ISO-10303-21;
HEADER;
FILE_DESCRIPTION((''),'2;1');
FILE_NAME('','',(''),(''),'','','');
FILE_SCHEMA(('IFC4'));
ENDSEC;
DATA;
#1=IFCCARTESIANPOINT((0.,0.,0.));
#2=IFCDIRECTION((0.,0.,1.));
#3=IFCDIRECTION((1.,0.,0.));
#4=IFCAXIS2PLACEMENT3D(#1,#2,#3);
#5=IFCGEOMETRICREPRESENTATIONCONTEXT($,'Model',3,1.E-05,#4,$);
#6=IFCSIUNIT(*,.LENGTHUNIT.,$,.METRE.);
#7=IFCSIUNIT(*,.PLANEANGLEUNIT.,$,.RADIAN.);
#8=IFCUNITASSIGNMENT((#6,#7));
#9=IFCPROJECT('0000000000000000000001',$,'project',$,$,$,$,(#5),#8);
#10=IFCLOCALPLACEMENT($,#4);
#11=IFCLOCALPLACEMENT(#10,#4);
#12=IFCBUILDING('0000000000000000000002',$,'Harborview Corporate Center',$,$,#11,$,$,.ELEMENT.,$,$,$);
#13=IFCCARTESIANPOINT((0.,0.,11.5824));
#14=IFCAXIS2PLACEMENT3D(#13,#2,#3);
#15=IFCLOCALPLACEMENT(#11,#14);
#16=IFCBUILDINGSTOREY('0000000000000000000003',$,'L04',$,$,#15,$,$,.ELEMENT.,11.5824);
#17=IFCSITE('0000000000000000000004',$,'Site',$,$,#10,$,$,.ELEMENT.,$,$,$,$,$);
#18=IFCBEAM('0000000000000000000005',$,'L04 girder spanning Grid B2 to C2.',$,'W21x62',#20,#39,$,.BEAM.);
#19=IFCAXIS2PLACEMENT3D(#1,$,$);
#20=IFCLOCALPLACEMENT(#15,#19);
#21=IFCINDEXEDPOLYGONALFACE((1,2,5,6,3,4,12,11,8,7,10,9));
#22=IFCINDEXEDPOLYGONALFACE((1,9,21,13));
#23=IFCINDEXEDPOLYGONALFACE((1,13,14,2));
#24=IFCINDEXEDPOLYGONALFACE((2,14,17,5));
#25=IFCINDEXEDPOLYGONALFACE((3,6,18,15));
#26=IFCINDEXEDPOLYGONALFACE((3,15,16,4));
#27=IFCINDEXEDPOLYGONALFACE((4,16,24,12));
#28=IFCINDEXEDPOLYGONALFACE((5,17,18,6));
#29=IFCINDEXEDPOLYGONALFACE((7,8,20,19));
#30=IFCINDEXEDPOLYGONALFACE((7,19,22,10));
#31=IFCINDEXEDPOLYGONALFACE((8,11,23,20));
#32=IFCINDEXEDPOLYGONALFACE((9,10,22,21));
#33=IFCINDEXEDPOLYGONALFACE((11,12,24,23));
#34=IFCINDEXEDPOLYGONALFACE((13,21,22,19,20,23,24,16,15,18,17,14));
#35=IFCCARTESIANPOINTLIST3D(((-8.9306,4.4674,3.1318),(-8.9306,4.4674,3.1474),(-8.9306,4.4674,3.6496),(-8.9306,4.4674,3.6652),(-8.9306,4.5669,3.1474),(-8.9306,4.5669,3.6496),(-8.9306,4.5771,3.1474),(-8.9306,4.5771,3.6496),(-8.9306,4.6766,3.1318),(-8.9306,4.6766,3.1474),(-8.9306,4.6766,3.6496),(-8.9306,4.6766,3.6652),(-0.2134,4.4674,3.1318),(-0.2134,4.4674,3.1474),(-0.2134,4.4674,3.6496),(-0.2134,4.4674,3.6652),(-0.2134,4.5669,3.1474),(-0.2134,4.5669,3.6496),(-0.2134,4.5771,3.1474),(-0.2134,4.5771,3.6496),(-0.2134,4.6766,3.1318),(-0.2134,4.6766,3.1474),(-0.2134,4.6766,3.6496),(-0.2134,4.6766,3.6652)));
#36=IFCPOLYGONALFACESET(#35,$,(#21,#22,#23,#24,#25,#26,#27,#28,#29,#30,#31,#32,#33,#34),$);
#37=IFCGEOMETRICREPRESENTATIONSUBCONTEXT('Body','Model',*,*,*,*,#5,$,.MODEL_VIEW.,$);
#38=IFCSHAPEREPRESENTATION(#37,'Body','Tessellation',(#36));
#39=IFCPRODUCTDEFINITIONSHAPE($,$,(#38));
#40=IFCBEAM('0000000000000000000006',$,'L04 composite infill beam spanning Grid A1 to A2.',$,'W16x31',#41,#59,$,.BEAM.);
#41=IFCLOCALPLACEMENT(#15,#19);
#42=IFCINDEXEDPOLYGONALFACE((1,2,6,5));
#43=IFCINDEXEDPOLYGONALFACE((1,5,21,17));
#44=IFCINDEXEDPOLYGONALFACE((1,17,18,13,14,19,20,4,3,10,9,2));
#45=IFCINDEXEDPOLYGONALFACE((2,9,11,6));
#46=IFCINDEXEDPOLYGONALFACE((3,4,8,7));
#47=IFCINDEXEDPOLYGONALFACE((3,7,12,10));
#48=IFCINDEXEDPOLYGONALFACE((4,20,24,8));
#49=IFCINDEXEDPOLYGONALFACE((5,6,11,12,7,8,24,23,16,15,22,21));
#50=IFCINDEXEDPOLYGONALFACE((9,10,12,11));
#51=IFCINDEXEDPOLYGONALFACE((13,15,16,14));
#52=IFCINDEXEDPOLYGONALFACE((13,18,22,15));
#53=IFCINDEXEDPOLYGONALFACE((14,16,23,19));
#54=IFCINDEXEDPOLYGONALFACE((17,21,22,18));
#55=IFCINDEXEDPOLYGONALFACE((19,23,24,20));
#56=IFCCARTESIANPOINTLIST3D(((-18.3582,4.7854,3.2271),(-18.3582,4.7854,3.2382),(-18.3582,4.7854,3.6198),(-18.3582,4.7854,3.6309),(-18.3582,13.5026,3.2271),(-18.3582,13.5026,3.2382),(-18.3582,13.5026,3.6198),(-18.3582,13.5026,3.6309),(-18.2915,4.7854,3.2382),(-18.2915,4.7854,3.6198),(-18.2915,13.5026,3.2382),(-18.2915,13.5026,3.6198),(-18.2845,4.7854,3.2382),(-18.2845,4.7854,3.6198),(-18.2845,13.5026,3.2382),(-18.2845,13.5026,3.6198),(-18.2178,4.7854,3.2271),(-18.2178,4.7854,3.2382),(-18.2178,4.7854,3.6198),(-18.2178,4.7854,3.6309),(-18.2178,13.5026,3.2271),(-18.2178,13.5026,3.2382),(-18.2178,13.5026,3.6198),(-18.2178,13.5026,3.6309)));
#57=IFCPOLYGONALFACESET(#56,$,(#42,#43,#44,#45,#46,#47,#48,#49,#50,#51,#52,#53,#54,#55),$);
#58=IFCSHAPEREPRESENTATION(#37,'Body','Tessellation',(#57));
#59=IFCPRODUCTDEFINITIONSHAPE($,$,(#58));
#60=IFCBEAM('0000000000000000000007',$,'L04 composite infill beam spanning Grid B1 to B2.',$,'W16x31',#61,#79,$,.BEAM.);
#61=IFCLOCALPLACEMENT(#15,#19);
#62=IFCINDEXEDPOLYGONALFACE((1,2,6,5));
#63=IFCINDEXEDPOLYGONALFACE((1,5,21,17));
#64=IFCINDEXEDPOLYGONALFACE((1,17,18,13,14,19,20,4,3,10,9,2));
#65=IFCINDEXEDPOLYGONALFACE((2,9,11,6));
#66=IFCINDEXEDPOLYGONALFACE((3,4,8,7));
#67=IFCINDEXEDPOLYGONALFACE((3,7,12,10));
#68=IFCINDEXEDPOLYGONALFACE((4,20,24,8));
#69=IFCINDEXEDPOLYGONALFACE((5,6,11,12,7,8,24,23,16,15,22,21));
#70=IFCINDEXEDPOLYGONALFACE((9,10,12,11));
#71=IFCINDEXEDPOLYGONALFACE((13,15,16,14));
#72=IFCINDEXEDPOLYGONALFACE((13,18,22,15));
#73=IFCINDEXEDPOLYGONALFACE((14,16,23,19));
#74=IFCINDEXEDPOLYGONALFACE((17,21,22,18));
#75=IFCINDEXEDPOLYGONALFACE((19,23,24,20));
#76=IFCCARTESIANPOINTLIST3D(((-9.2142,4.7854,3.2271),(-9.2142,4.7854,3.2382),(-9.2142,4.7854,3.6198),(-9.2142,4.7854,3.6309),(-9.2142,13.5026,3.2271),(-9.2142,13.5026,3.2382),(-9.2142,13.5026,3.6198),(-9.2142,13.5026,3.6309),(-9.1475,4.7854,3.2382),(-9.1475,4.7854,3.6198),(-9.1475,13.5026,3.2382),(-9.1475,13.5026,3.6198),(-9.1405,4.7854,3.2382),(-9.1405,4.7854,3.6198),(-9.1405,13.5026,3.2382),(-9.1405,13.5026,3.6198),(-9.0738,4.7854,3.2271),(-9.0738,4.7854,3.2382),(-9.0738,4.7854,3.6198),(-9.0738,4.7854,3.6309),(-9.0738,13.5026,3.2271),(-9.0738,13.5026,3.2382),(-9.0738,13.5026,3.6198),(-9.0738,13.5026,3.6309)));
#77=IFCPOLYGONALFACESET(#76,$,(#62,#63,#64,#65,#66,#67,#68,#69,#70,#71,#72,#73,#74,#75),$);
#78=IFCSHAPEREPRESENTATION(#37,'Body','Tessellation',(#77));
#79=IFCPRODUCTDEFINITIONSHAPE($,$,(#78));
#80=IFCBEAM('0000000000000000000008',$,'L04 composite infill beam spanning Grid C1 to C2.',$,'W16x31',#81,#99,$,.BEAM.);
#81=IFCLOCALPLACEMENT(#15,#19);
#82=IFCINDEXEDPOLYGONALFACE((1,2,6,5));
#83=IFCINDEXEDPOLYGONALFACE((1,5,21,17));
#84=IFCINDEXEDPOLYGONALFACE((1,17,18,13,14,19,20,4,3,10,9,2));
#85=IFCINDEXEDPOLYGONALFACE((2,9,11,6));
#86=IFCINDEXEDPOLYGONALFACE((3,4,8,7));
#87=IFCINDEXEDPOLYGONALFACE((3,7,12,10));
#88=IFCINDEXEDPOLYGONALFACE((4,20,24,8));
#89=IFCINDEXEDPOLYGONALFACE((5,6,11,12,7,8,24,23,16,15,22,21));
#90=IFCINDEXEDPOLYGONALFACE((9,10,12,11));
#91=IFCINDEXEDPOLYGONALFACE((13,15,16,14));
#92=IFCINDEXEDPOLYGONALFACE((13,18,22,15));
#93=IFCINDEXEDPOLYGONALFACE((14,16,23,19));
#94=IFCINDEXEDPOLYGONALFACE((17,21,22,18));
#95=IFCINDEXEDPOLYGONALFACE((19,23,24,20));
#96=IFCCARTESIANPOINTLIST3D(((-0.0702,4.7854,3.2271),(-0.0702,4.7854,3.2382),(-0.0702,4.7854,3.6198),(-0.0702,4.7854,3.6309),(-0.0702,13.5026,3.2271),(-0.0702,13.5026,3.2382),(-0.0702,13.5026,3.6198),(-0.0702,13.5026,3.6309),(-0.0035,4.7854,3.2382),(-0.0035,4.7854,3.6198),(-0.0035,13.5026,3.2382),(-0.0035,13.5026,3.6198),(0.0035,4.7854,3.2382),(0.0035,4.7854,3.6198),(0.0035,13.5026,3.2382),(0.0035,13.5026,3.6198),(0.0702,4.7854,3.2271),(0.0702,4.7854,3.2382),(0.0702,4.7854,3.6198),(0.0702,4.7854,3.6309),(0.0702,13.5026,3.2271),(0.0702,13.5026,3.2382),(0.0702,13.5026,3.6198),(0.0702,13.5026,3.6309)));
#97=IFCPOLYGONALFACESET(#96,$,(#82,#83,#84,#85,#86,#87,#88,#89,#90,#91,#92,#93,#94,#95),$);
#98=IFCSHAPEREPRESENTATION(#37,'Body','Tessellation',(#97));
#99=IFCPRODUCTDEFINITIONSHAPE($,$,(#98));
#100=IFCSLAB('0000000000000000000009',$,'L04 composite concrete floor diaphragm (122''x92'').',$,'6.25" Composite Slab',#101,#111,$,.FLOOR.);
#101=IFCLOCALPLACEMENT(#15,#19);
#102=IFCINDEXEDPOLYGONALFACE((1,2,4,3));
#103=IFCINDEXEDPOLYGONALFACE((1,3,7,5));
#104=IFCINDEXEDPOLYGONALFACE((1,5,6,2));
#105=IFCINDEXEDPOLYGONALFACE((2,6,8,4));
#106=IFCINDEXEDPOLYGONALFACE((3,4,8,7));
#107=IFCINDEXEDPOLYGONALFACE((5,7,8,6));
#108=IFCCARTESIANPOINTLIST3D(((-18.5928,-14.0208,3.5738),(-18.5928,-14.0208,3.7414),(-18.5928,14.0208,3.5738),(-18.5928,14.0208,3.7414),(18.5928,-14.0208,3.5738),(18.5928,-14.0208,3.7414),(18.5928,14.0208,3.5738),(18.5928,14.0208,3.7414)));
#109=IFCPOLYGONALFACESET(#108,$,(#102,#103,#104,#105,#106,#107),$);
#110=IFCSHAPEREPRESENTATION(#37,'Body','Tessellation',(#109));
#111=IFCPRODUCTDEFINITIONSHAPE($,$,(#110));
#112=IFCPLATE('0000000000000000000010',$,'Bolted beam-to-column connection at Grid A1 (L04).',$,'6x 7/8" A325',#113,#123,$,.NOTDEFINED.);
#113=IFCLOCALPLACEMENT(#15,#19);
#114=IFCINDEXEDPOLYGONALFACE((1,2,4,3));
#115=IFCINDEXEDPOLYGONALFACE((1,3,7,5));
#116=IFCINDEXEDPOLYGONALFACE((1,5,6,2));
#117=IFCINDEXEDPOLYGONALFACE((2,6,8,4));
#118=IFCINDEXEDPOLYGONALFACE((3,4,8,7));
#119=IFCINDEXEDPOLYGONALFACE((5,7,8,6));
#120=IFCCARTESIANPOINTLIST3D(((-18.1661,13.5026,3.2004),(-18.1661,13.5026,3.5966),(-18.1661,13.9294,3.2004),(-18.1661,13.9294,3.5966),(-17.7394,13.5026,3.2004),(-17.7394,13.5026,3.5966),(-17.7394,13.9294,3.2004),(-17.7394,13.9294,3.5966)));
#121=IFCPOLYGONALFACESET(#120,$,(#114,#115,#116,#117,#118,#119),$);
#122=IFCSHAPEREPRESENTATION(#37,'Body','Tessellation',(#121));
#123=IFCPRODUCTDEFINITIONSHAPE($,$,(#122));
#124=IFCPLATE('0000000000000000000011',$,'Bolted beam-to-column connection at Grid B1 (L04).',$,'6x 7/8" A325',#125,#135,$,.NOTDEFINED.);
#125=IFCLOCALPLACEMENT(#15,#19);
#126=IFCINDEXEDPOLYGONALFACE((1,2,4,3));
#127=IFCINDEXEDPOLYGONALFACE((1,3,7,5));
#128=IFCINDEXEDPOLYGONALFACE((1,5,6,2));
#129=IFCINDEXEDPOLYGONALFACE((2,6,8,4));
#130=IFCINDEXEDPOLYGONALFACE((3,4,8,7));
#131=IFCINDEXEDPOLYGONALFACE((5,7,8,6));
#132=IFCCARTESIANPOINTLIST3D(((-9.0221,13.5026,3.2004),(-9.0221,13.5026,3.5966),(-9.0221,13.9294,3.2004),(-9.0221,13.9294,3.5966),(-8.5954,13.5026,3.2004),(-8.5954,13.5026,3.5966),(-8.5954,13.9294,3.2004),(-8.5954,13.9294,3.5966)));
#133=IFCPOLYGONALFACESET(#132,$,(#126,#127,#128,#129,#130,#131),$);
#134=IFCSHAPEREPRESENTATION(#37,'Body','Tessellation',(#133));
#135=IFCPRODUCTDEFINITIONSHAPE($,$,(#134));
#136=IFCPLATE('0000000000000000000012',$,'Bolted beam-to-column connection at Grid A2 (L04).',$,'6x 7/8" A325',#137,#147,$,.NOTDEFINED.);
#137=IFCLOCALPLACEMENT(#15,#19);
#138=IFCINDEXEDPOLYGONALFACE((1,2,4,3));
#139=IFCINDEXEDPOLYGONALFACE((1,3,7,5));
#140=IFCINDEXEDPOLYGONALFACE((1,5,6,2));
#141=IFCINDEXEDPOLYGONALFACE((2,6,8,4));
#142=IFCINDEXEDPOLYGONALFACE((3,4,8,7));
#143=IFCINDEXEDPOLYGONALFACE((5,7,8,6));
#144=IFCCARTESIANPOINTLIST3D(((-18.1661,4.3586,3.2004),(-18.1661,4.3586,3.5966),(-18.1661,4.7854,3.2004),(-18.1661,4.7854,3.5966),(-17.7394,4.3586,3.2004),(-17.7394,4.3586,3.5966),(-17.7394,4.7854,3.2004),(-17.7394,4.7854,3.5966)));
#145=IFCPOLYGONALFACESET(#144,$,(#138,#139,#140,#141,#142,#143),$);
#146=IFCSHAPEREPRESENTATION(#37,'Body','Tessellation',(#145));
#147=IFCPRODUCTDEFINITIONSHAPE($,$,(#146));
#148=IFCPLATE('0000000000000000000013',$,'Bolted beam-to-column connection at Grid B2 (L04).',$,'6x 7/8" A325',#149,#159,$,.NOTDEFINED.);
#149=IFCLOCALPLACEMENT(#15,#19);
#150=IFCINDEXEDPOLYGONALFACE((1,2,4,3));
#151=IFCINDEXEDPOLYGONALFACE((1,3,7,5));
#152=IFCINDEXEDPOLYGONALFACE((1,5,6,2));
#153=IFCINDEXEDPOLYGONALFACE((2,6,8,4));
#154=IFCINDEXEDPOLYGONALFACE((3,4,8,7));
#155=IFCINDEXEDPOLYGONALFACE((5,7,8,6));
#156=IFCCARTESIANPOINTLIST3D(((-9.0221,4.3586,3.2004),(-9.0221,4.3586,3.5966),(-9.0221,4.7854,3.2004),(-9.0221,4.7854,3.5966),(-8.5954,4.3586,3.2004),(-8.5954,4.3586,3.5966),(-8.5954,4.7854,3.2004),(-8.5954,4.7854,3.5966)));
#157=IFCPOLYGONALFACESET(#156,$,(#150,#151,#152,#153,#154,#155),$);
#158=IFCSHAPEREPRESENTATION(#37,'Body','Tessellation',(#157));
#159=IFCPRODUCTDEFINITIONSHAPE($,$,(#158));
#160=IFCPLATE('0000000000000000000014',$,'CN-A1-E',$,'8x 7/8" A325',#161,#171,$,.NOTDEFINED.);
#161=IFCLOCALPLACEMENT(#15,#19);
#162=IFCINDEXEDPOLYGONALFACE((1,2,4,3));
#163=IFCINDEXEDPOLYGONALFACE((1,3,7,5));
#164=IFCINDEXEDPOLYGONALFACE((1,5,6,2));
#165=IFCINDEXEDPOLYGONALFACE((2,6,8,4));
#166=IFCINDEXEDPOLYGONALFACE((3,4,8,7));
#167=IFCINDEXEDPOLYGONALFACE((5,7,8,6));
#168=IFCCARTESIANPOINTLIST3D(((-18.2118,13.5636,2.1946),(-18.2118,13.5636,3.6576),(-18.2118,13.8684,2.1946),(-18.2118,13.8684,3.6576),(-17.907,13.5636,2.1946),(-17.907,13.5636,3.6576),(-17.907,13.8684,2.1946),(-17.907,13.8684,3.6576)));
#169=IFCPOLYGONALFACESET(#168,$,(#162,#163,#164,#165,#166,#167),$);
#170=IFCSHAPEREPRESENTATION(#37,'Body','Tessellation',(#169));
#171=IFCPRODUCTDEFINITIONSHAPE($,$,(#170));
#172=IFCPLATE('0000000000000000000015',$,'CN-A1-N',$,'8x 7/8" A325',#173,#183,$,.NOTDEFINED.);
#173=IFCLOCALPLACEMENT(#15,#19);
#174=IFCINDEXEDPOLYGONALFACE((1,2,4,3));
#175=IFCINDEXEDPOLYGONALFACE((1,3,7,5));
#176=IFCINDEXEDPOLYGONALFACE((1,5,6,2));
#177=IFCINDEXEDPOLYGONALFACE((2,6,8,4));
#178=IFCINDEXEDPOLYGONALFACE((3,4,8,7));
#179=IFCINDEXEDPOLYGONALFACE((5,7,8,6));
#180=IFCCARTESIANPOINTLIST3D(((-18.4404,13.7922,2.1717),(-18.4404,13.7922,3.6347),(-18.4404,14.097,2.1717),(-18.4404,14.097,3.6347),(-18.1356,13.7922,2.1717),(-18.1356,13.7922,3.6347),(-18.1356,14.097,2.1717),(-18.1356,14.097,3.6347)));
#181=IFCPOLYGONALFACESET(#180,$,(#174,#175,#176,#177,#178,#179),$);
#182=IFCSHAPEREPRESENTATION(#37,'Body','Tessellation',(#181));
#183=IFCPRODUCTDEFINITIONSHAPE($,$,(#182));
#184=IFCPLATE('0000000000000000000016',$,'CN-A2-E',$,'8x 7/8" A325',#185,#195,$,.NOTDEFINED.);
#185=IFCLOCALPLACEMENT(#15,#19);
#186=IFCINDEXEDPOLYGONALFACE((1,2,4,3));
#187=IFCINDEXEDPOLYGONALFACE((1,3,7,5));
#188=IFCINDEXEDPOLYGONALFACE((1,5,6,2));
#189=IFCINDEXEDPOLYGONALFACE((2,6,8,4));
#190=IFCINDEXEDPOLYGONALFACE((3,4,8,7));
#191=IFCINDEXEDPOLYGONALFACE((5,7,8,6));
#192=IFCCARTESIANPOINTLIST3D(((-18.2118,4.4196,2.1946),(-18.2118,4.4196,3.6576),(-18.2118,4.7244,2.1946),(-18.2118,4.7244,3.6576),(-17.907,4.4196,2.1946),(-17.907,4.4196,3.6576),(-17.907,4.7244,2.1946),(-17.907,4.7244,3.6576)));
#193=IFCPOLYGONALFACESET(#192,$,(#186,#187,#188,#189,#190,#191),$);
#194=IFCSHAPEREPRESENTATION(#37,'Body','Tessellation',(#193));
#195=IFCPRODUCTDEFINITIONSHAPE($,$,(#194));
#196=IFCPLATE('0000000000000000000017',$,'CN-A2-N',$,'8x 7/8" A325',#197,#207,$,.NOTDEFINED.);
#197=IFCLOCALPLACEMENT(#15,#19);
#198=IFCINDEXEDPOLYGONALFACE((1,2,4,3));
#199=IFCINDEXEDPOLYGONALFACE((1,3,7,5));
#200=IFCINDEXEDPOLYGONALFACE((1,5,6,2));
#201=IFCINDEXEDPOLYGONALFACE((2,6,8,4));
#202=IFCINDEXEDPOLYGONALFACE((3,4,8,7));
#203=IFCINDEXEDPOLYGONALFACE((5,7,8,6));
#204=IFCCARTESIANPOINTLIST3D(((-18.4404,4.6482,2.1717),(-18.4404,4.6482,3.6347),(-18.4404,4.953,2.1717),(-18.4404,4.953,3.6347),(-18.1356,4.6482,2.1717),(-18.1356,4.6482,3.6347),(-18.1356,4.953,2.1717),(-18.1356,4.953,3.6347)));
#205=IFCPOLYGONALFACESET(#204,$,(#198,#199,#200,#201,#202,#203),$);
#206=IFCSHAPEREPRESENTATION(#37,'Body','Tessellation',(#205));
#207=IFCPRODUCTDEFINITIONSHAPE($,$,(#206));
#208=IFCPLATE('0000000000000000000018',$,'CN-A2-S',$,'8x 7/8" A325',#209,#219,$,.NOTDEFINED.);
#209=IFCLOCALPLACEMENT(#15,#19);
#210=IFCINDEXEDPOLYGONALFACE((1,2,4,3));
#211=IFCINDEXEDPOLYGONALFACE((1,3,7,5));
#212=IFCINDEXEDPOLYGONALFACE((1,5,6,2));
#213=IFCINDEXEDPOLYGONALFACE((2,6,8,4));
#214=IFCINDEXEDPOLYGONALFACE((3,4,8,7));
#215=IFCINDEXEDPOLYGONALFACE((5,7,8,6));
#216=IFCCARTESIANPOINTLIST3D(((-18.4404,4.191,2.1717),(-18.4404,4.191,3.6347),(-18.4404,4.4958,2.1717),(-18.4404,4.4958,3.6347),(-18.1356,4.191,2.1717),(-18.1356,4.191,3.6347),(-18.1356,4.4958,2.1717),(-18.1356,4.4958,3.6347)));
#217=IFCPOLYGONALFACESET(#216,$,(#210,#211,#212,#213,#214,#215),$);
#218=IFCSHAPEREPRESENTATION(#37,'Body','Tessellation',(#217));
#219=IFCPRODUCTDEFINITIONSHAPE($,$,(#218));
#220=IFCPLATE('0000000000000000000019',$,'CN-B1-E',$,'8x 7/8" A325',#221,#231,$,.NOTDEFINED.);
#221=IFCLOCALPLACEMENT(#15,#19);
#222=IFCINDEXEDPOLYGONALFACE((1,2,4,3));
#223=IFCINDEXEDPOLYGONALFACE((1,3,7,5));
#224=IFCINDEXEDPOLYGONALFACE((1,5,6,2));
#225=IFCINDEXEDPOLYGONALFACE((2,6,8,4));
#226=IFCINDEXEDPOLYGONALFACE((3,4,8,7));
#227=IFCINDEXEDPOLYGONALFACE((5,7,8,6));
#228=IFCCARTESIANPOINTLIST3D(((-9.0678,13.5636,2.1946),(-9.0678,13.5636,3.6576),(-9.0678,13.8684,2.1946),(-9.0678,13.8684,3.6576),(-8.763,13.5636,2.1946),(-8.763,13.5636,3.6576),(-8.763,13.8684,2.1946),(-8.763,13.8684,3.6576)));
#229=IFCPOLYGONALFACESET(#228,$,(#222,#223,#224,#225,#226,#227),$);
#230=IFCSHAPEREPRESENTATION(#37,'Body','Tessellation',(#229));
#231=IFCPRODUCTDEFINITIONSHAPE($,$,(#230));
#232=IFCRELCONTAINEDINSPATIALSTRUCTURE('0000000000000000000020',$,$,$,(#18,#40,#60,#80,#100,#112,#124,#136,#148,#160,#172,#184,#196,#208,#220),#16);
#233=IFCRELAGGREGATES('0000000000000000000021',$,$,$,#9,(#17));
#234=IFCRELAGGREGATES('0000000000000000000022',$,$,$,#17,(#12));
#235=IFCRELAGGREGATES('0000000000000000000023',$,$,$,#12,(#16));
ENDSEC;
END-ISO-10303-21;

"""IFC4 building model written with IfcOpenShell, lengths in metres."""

from ifc_helpers import new_model, si_unit, frame, origin_with_axes, place, context, subcontext, project, spatial, rectangle, i_section, extrude, element, save


model = new_model("IFC4")

# Units and contexts
model_context = context("Model", 3, precision=1e-05, world=origin_with_axes())
body_context = subcontext(model_context, "Body", "Model", "MODEL_VIEW")
ifc_project = project(units=[si_unit("LENGTHUNIT", "METRE"), si_unit("PLANEANGLEUNIT", "RADIAN")], contexts=[model_context])

# Site, building, storey
site_placement = place(None, origin_with_axes())
site = spatial("IfcSite", under=ifc_project, at=site_placement, Name="Site", CompositionType="ELEMENT")
building_placement = place(site_placement, origin_with_axes())
building = spatial("IfcBuilding", under=site, at=building_placement, Name="Harborview Corporate Center", CompositionType="ELEMENT")
storey_placement = place(building_placement, frame((0.0, 0.0, 11.5824), z_axis=(0.0, 0.0, 1.0), x_axis=(1.0, 0.0, 0.0)))
storey = spatial("IfcBuildingStorey", under=building, at=storey_placement, Name="L04", CompositionType="ELEMENT", Elevation=11.5824)

# Beams
beam_1_placement = place(storey_placement, frame((-8.9306, 4.572, 3.3985), z_axis=(1.0, 0.0, 0.0), x_axis=(0.0, 1.0, 0.0)))
element("IfcBeam", 1, at=beam_1_placement, inside=storey, Name="L04 girder spanning Grid B2 to C2.", ObjectType="W21x62", PredefinedType="BEAM", context=body_context, shape_type="SweptSolid", body=[
    extrude(i_section(OverallWidth=0.2093, OverallDepth=0.5334, WebThickness=0.0102, FlangeThickness=0.0156), origin_with_axes(), (0.0, 0.0, 1.0), 8.7173),
])
for number, where, z_axis, x_axis, name in (
    (2, (-18.288, 4.7854, 3.429), (0.0, 1.0, 0.0), (-1.0, 0.0, 0.0), "L04 composite infill beam spanning Grid A1 to A2."),
    (3, (-9.144, 4.7854, 3.429), (0.0, 1.0, 0.0), (-1.0, 0.0, 0.0), "L04 composite infill beam spanning Grid B1 to B2."),
    (4, (0.0, 4.7854, 3.429), (0.0, 1.0, 0.0), (-1.0, 0.0, 0.0), "L04 composite infill beam spanning Grid C1 to C2."),
):
    element("IfcBeam", number, at=place(storey_placement, frame(where, z_axis=z_axis, x_axis=x_axis)), inside=storey, Name=name, ObjectType="W16x31", PredefinedType="BEAM", context=body_context, shape_type="SweptSolid", body=[
        extrude(i_section(OverallWidth=0.1405, OverallDepth=0.4039, WebThickness=0.007, FlangeThickness=0.0112), origin_with_axes(), (0.0, 0.0, 1.0), 8.7173),
    ])

# Slab
slab_placement = place(storey_placement, frame((0.0, 0.0, 3.5738), z_axis=(0.0, 0.0, 1.0), x_axis=(1.0, 0.0, 0.0)))
element("IfcSlab", 5, at=slab_placement, inside=storey, Name="L04 composite concrete floor diaphragm (122'x92').", ObjectType="6.25\" Composite Slab", PredefinedType="FLOOR", context=body_context, shape_type="SweptSolid", body=[
    extrude(rectangle(XDim=37.1856, YDim=28.0416), origin_with_axes(), (0.0, 0.0, 1.0), 0.1676),
])

# Plates
plate_1_placement = place(storey_placement, frame((-17.9527, 13.716, 3.2004), z_axis=(0.0, 0.0, 1.0), x_axis=(1.0, 0.0, 0.0)))
element("IfcPlate", 6, at=plate_1_placement, inside=storey, Name="Bolted beam-to-column connection at Grid A1 (L04).", ObjectType="6x 7/8\" A325", PredefinedType="NOTDEFINED", context=body_context, shape_type="SweptSolid", body=[
    extrude(rectangle(XDim=0.4267, YDim=0.4267), origin_with_axes(), (0.0, 0.0, 1.0), 0.3962),
])
plate_2_placement = place(storey_placement, frame((-8.8087, 13.716, 3.2004), z_axis=(0.0, 0.0, 1.0), x_axis=(1.0, 0.0, 0.0)))
element("IfcPlate", 7, at=plate_2_placement, inside=storey, Name="Bolted beam-to-column connection at Grid B1 (L04).", ObjectType="6x 7/8\" A325", PredefinedType="NOTDEFINED", context=body_context, shape_type="SweptSolid", body=[
    extrude(rectangle(XDim=0.4267, YDim=0.4267), origin_with_axes(), (0.0, 0.0, 1.0), 0.3962),
])
plate_3_placement = place(storey_placement, frame((-17.9527, 4.572, 3.2004), z_axis=(0.0, 0.0, 1.0), x_axis=(1.0, 0.0, 0.0)))
element("IfcPlate", 8, at=plate_3_placement, inside=storey, Name="Bolted beam-to-column connection at Grid A2 (L04).", ObjectType="6x 7/8\" A325", PredefinedType="NOTDEFINED", context=body_context, shape_type="SweptSolid", body=[
    extrude(rectangle(XDim=0.4267, YDim=0.4267), origin_with_axes(), (0.0, 0.0, 1.0), 0.3962),
])
plate_4_placement = place(storey_placement, frame((-8.8087, 4.572, 3.2004), z_axis=(0.0, 0.0, 1.0), x_axis=(1.0, 0.0, 0.0)))
element("IfcPlate", 9, at=plate_4_placement, inside=storey, Name="Bolted beam-to-column connection at Grid B2 (L04).", ObjectType="6x 7/8\" A325", PredefinedType="NOTDEFINED", context=body_context, shape_type="SweptSolid", body=[
    extrude(rectangle(XDim=0.4267, YDim=0.4267), origin_with_axes(), (0.0, 0.0, 1.0), 0.3962),
])
for number, where, z_axis, x_axis, name in (
    (10, (-18.0594, 13.716, 2.1946), (0.0, 0.0, 1.0), (1.0, 0.0, 0.0), "CN-A1-E"),
    (11, (-18.288, 13.9446, 2.1717), (0.0, 0.0, 1.0), (1.0, 0.0, 0.0), "CN-A1-N"),
    (12, (-18.0594, 4.572, 2.1946), (0.0, 0.0, 1.0), (1.0, 0.0, 0.0), "CN-A2-E"),
    (13, (-18.288, 4.8006, 2.1717), (0.0, 0.0, 1.0), (1.0, 0.0, 0.0), "CN-A2-N"),
    (14, (-18.288, 4.3434, 2.1717), (0.0, 0.0, 1.0), (1.0, 0.0, 0.0), "CN-A2-S"),
    (15, (-8.9154, 13.716, 2.1946), (0.0, 0.0, 1.0), (1.0, 0.0, 0.0), "CN-B1-E"),
):
    element("IfcPlate", number, at=place(storey_placement, frame(where, z_axis=z_axis, x_axis=x_axis)), inside=storey, Name=name, ObjectType="8x 7/8\" A325", PredefinedType="NOTDEFINED", context=body_context, shape_type="SweptSolid", body=[
        extrude(rectangle(XDim=0.3048, YDim=0.3048), origin_with_axes(), (0.0, 0.0, 1.0), 1.463),
    ])

save(model, "model.ifc")
